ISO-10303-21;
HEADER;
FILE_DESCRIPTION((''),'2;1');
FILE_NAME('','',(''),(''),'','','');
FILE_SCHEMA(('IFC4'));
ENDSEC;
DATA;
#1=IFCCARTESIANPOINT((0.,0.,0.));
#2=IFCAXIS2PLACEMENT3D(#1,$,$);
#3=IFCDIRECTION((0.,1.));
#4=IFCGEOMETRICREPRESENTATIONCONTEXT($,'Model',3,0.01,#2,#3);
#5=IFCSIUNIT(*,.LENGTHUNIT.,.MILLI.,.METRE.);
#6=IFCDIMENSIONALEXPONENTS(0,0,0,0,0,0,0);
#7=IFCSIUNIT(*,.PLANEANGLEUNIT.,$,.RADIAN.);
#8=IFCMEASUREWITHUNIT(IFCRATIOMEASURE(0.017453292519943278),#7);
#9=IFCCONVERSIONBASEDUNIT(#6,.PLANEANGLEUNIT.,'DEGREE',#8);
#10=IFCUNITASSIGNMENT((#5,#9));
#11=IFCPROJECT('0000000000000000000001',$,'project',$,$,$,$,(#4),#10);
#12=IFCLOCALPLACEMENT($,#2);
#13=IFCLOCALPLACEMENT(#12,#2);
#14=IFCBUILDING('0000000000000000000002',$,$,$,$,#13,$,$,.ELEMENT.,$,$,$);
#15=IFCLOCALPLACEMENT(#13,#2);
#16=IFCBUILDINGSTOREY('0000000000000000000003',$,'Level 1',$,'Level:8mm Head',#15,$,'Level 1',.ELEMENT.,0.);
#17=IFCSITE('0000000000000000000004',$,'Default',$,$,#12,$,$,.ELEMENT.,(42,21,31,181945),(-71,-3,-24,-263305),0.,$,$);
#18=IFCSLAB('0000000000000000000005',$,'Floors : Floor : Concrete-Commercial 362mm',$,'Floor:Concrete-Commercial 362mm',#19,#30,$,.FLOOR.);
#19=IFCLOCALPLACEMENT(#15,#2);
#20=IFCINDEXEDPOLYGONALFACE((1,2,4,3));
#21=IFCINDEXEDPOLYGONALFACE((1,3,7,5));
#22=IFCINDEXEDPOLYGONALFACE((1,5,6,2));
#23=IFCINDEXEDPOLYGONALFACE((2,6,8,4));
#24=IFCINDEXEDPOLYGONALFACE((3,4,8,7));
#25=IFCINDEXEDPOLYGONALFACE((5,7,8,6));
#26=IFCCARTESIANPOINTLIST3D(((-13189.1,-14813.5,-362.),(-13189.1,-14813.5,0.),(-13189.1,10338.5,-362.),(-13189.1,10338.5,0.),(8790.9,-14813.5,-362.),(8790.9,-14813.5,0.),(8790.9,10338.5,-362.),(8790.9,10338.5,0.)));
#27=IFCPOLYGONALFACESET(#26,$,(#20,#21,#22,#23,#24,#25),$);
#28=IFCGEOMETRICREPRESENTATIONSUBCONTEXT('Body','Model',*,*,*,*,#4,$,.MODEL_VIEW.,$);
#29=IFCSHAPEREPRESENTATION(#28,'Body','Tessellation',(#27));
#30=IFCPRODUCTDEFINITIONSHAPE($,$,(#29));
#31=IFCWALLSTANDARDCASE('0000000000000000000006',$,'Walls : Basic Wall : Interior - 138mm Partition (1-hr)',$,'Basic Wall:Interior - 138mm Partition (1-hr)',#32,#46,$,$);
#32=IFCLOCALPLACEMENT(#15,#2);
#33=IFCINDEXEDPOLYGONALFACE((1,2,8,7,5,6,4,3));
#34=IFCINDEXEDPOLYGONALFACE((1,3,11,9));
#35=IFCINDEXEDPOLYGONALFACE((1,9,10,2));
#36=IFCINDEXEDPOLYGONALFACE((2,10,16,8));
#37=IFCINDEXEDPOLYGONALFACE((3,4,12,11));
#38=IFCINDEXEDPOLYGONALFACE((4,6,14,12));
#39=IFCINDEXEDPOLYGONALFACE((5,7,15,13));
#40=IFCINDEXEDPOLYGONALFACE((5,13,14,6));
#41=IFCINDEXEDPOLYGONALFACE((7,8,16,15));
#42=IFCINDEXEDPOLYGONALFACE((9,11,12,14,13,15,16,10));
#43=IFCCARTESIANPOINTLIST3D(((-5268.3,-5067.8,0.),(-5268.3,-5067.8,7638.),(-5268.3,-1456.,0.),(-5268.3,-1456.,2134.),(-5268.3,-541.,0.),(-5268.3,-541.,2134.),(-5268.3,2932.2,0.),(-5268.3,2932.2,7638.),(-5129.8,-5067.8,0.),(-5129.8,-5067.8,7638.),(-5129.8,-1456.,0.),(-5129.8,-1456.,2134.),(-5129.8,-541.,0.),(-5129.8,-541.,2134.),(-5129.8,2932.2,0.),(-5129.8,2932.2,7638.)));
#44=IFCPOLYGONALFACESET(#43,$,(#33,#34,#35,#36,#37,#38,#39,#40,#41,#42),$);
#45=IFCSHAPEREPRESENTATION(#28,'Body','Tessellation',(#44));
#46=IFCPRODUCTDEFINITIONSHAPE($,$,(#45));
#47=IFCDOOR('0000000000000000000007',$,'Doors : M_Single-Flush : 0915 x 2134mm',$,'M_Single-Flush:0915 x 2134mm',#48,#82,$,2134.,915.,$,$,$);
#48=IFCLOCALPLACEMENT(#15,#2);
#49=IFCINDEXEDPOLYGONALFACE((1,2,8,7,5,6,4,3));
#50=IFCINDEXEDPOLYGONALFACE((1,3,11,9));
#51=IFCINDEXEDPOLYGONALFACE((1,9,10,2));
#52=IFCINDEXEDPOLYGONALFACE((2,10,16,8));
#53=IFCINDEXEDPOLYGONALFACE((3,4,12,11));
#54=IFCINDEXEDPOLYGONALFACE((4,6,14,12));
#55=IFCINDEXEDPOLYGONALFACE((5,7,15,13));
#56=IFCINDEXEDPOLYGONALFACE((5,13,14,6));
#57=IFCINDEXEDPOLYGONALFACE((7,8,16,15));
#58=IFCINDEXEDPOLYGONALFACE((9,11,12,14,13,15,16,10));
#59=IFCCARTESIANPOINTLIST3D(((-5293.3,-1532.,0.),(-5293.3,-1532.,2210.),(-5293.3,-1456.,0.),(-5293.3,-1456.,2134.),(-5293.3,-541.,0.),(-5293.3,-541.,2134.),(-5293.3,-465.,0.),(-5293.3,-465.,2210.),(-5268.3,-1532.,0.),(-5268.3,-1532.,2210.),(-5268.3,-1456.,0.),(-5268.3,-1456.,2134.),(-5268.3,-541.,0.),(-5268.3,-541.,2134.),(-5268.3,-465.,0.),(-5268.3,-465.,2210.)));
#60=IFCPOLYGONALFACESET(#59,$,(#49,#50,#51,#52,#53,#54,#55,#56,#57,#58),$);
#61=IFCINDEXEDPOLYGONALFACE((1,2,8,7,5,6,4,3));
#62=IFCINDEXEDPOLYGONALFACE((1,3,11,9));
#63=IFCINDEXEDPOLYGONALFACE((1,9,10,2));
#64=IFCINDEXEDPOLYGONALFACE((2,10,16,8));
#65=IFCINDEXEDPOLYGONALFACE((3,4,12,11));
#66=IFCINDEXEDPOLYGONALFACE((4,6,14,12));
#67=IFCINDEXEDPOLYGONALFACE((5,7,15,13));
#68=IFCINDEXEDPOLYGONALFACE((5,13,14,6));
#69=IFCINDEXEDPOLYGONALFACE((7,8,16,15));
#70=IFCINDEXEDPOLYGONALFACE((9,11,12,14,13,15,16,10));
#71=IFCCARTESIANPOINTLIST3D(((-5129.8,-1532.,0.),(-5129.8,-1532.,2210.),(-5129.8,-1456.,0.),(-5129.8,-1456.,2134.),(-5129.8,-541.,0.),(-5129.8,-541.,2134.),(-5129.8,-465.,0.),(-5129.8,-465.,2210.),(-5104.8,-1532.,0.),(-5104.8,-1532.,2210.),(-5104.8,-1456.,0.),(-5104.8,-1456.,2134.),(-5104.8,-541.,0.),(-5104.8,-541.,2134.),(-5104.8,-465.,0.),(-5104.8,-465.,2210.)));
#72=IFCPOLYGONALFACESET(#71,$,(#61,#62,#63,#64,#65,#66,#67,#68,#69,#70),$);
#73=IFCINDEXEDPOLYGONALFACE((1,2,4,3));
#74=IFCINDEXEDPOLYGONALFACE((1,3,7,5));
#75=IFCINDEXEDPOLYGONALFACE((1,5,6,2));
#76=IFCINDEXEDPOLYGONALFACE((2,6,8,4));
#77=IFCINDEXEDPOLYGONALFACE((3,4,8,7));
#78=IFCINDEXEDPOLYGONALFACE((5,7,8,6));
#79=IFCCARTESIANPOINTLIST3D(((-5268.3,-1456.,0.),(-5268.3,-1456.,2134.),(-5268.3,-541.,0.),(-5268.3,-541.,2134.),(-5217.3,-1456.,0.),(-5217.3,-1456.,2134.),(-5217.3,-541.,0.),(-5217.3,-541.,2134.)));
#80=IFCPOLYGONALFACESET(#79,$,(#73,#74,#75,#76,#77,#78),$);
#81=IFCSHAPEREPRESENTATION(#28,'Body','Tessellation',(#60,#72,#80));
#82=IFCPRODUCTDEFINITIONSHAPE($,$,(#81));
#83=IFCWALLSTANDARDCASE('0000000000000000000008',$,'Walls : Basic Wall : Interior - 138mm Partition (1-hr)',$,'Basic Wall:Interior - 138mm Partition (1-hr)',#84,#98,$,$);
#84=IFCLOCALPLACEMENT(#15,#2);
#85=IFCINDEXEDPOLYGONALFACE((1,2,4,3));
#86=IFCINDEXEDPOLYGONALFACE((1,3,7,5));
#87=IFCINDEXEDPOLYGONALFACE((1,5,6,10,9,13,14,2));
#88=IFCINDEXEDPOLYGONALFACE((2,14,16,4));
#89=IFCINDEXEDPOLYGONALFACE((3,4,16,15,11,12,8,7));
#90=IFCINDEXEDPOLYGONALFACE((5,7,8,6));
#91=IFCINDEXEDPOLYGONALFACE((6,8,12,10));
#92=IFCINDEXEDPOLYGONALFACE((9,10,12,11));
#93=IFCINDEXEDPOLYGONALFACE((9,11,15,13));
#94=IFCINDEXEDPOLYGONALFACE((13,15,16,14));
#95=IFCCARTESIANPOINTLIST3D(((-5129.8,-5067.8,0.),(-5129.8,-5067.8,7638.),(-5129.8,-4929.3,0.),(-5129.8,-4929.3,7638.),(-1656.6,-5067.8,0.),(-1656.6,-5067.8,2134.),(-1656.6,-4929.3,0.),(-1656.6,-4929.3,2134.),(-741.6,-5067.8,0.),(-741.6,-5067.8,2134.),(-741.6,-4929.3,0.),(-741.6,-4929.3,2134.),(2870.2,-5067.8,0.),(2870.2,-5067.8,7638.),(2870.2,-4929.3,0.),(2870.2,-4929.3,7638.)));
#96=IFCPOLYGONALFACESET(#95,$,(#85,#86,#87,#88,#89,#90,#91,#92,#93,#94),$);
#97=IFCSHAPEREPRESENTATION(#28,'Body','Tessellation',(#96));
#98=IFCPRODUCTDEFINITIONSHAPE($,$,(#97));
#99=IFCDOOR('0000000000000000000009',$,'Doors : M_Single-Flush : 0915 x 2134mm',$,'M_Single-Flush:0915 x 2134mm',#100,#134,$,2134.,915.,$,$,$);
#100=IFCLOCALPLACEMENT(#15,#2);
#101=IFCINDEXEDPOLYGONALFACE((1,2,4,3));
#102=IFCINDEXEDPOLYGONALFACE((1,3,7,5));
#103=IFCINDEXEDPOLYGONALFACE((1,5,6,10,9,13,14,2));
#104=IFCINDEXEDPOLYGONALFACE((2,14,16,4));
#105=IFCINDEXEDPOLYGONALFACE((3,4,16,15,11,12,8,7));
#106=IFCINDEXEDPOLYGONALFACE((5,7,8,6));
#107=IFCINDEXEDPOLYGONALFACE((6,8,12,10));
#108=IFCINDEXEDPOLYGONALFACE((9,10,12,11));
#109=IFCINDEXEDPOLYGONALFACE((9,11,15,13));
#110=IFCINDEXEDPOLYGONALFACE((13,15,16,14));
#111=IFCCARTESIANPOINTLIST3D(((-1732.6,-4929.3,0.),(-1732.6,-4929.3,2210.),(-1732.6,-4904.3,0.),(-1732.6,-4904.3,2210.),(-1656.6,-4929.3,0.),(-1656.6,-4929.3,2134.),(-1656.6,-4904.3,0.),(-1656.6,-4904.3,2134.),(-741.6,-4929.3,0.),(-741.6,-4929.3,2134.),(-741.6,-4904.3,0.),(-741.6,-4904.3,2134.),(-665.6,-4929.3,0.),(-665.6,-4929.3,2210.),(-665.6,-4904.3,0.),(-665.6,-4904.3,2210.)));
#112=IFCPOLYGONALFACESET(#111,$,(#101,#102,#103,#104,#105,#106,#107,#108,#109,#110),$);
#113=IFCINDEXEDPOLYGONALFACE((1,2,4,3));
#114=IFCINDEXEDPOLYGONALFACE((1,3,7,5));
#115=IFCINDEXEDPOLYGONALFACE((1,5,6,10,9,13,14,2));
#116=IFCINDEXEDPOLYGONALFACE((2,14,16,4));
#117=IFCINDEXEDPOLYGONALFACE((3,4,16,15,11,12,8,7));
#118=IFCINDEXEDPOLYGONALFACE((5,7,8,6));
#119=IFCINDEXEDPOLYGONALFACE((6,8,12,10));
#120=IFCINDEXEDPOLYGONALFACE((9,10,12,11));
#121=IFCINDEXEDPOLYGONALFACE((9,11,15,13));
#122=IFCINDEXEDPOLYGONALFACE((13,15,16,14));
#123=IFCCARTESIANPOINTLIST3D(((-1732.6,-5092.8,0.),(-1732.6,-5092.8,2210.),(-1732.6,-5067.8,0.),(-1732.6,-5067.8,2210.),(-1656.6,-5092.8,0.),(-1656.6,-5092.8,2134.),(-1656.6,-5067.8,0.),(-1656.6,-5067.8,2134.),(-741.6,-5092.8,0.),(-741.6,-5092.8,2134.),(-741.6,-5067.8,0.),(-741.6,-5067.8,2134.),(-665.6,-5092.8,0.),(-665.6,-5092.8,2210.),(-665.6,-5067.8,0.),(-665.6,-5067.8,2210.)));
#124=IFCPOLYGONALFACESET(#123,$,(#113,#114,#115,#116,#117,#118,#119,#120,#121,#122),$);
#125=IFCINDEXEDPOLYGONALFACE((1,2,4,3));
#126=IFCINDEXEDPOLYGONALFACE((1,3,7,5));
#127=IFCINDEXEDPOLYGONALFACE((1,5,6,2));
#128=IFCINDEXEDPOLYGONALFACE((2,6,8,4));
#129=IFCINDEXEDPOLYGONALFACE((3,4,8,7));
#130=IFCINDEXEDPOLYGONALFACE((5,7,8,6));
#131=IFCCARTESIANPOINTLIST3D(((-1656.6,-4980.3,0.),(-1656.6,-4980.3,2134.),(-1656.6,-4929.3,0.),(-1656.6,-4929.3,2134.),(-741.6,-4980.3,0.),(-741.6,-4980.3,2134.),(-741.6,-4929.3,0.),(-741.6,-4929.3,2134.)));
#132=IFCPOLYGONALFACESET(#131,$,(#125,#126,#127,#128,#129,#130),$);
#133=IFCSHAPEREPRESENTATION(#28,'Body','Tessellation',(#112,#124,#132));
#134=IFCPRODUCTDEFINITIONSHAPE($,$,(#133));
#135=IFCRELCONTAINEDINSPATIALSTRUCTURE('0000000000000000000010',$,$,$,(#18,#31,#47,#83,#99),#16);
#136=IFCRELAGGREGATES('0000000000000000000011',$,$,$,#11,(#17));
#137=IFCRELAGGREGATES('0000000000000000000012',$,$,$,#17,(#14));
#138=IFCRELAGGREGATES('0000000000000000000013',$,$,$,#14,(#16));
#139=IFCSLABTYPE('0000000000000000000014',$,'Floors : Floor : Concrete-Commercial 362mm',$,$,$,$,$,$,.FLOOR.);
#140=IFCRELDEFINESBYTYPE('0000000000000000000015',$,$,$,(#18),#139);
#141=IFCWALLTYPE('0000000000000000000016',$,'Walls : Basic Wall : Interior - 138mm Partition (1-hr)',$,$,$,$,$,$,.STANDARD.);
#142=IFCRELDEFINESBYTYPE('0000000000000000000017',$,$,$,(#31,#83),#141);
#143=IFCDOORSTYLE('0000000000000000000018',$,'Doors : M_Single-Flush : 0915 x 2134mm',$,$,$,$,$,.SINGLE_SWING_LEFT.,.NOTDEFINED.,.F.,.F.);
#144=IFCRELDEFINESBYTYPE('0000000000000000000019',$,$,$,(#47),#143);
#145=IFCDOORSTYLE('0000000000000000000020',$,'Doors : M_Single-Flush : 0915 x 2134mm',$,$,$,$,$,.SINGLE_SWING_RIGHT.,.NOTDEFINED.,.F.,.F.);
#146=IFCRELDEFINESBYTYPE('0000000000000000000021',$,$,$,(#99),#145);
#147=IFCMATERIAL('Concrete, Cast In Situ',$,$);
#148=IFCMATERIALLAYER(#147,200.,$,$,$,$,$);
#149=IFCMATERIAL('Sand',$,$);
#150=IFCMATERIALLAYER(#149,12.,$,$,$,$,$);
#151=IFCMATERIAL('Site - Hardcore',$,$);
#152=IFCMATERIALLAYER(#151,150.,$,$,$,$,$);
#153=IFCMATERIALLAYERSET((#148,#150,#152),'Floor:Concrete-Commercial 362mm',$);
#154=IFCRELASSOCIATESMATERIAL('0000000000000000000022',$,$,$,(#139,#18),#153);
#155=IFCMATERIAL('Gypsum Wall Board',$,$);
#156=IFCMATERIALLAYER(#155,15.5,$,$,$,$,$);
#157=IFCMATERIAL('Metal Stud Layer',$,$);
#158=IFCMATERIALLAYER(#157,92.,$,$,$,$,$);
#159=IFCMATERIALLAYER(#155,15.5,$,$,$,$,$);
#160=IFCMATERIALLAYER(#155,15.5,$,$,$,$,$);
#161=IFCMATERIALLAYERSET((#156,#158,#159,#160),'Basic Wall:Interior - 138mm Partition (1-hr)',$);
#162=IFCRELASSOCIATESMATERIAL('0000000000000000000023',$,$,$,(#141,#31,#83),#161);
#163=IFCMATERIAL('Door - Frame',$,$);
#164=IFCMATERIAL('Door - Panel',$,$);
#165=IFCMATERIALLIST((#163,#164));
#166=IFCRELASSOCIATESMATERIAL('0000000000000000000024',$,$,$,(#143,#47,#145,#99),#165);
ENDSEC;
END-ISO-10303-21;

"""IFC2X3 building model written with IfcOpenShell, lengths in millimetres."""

from ifc_helpers import new_model, entity, si_unit, converted_unit, direction, frame, frame_2d, origin, place, context, subcontext, project, spatial, polyline, rectangle, outline, extrude, clip, bounded_halfspace, source, transform, mapped, material, material_list, layer, layer_set, layer_usage, type_object, type_shapes, element, fill, save


model = new_model("IFC2X3")

# Units and contexts
model_context = context("Model", 3, precision=0.01, world=origin(), true_north=direction((0.0, 1.0)))
body_context = subcontext(model_context, "Body", "Model", "MODEL_VIEW")
ifc_project = project(units=[si_unit("LENGTHUNIT", "METRE", prefix="MILLI"), converted_unit("PLANEANGLEUNIT", "DEGREE", entity("IfcRatioMeasure", 0.017453292519943278), si_unit("PLANEANGLEUNIT", "RADIAN"), dimensions=[0, 0, 0, 0, 0, 0, 0])], contexts=[model_context])

# Site, building, storey
site_placement = place(None, origin())
site = spatial("IfcSite", under=ifc_project, at=site_placement, Name="Default", CompositionType="ELEMENT", RefLatitude=(42, 21, 31, 181945), RefLongitude=(-71, -3, -24, -263305), RefElevation=0.0)
building_placement = place(site_placement, origin())
building = spatial("IfcBuilding", under=site, at=building_placement, CompositionType="ELEMENT")
storey_placement = place(building_placement, origin())
storey = spatial("IfcBuildingStorey", under=building, at=storey_placement, Name="Level 1", ObjectType="Level:8mm Head", LongName="Level 1", CompositionType="ELEMENT", Elevation=0.0)

# Slab
ifc_material_1 = material(Name="Concrete, Cast In Situ")
ifc_layer_1 = layer(ifc_material_1, 200.0)
ifc_material_2 = material(Name="Sand")
ifc_layer_2 = layer(ifc_material_2, 12.0)
ifc_material_3 = material(Name="Site - Hardcore")
ifc_layer_3 = layer(ifc_material_3, 150.0)
ifc_layer_set_1 = layer_set([ifc_layer_1, ifc_layer_2, ifc_layer_3], Name="Floor:Concrete-Commercial 362mm")
ifc_layer_usage_1 = layer_usage(ifc_layer_set_1, "AXIS3", "POSITIVE", 0.0)
slab_type = type_object("IfcSlabType", Name="Floors : Floor : Concrete-Commercial 362mm", PredefinedType="FLOOR", material=ifc_layer_set_1)
slab_placement = place(storey_placement, origin())
element("IfcSlab", 1, at=slab_placement, inside=storey, type_object=slab_type, material=ifc_layer_usage_1, Name="Floors : Floor : Concrete-Commercial 362mm", ObjectType="Floor:Concrete-Commercial 362mm", PredefinedType="FLOOR", context=body_context, shape_type="SweptSolid", body=[
    extrude(rectangle(XDim=25152.0, YDim=21980.0, at=frame_2d((0.0, 0.0), x_axis=(1.0, 0.0))), frame((-2199.1, -2237.5, 0.0), z_axis=(0.0, 0.0, -1.0), x_axis=(0.0, 1.0, 0.0)), (0.0, 0.0, 1.0), 362.0),
])

# Shared definitions
ifc_material_4 = material(Name="Metal Stud Layer")
ifc_material_5 = material(Name="Gypsum Wall Board")
ifc_layer_4 = layer(ifc_material_5, 15.5)
ifc_layer_5 = layer(ifc_material_4, 92.0)
ifc_layer_6 = layer(ifc_material_5, 15.5)
ifc_layer_7 = layer(ifc_material_5, 15.5)
ifc_layer_set_2 = layer_set([ifc_layer_4, ifc_layer_5, ifc_layer_6, ifc_layer_7], Name="Basic Wall:Interior - 138mm Partition (1-hr)")
wall_type_1 = type_object("IfcWallType", Name="Walls : Basic Wall : Interior - 138mm Partition (1-hr)", PredefinedType="STANDARD", material=ifc_layer_set_2)

# Walls, openings, doors
ifc_layer_usage_2 = layer_usage(ifc_layer_set_2, "AXIS2", "NEGATIVE", 69.2)
wall_1_placement = place(storey_placement, frame((-5199.1, 2932.2, 0.0), z_axis=(0.0, 0.0, 1.0), x_axis=(0.0, -1.0, 0.0)))
wall_1 = element("IfcWallStandardCase", 2, at=wall_1_placement, inside=storey, type_object=wall_type_1, material=ifc_layer_usage_2, Name="Walls : Basic Wall : Interior - 138mm Partition (1-hr)", ObjectType="Basic Wall:Interior - 138mm Partition (1-hr)", context=body_context, shape_type="Clipping", body=[
    clip(extrude(rectangle(XDim=8000.0, YDim=138.5, at=frame_2d((4000.0, 0.0), x_axis=(1.0, 0.0))), origin(), (0.0, 0.0, 1.0), 7638.0), bounded_halfspace(frame((0.0, -69.2, 7638.0), z_axis=(0.0, 0.0, -1.0), x_axis=(1.0, 0.0, 0.0)), True, frame((0.0, -69.2, 7638.0)), polyline([(0.0, 0.0), (2438400.0, 0.0), (2438400.0, 42214.8), (2396185.2, 42214.8), (0.0, 42214.8), (0.0, 0.0)]))),
])
opening_1_placement = place(wall_1_placement, frame((4388.2, 69.3, 0.0)))
opening_1 = element("IfcOpeningElement", 3, at=opening_1_placement, cuts=wall_1, ObjectType="Opening", context=body_context, shape_type="SweptSolid", body=[
    extrude(rectangle(XDim=915.0, YDim=2134.0, at=frame_2d((1067.0, 457.5), x_axis=(0.0, -1.0))), frame((0.0, 0.0, 0.0), z_axis=(0.0, -1.0, 0.0), x_axis=(0.0, 0.0, 1.0)), (0.0, 0.0, 1.0), 138.5),
])
ifc_material_6 = material(Name="Door - Frame")
ifc_material_7 = material(Name="Door - Panel")
ifc_material_list = material_list([ifc_material_6, ifc_material_7])
door_style_1 = type_object("IfcDoorStyle", Name="Doors : M_Single-Flush : 0915 x 2134mm", ConstructionType="NOTDEFINED", OperationType="SINGLE_SWING_LEFT", ParameterTakesPrecedence=False, Sizeable=False, material=ifc_material_list)
shared_shape_1 = source(origin(), body_context, "Body", "SweptSolid", [
    extrude(outline(polyline([(-533.5, -1124.0), (533.5, -1124.0), (533.5, 1086.0), (457.5, 1086.0), (457.5, -1048.0), (-457.5, -1048.0), (-457.5, 1086.0), (-533.5, 1086.0), (-533.5, -1124.0)])), frame((457.5, 163.5, 1086.0), z_axis=(0.0, -1.0, 0.0), x_axis=(-1.0, 0.0, 0.0)), (0.0, 0.0, 1.0), 25.0),
    extrude(outline(polyline([(-1124.0, -533.5), (1086.0, -533.5), (1086.0, -457.5), (-1048.0, -457.5), (-1048.0, 457.5), (1086.0, 457.5), (1086.0, 533.5), (-1124.0, 533.5), (-1124.0, -533.5)])), frame((457.5, 0.0, 1086.0), z_axis=(0.0, -1.0, 0.0), x_axis=(0.0, 0.0, -1.0)), (0.0, 0.0, 1.0), 25.0),
    extrude(rectangle(XDim=915.0, YDim=51.0, at=frame_2d((0.0, 0.0), x_axis=(1.0, 0.0))), frame((457.5, 113.0, 0.0)), (0.0, 0.0, 1.0), 2134.0),
])
type_shapes(door_style_1, [shared_shape_1])
door_1_placement = place(opening_1_placement, frame((0.0, 0.0, 0.0), z_axis=(0.0, 0.0, 1.0), x_axis=(-1.0, 0.0, 0.0)))
door_1 = element("IfcDoor", 4, at=door_1_placement, inside=storey, type_object=door_style_1, material=ifc_material_list, Name="Doors : M_Single-Flush : 0915 x 2134mm", ObjectType="M_Single-Flush:0915 x 2134mm", OverallHeight=2134.0, OverallWidth=915.0, context=body_context, shape_type="MappedRepresentation", body=[
    mapped(shared_shape_1, transform((0.0, 0.0, 0.0), scale=1.0)),
])
fill(opening_1, door_1)
wall_2_placement = place(storey_placement, frame((-5129.8, -4998.5, 0.0)))
wall_2 = element("IfcWallStandardCase", 5, at=wall_2_placement, inside=storey, type_object=wall_type_1, material=ifc_layer_usage_2, Name="Walls : Basic Wall : Interior - 138mm Partition (1-hr)", ObjectType="Basic Wall:Interior - 138mm Partition (1-hr)", context=body_context, shape_type="Clipping", body=[
    clip(extrude(rectangle(XDim=8000.0, YDim=138.5, at=frame_2d((4000.0, 0.0), x_axis=(1.0, 0.0))), origin(), (0.0, 0.0, 1.0), 7638.0), bounded_halfspace(frame((0.0, -69.2, 7638.0), z_axis=(0.0, 0.0, -1.0), x_axis=(0.0, -1.0, 0.0)), True, frame((0.0, -69.2, 7638.0)), polyline([(0.0, 0.0), (2396185.2, 0.0), (2438400.0, 0.0), (2438400.0, 42214.8), (0.0, 42214.8), (0.0, 0.0)]))),
])
opening_2_placement = place(wall_2_placement, frame((3473.2, -69.3, 0.0)))
opening_2 = element("IfcOpeningElement", 6, at=opening_2_placement, cuts=wall_2, ObjectType="Opening", context=body_context, shape_type="SweptSolid", body=[
    extrude(rectangle(XDim=915.0, YDim=2134.0, at=frame_2d((1067.0, 457.5), x_axis=(0.0, 1.0))), frame((0.0, 0.0, 0.0), z_axis=(0.0, 1.0, 0.0), x_axis=(0.0, 0.0, 1.0)), (0.0, 0.0, 1.0), 138.5),
])
door_style_2 = type_object("IfcDoorStyle", Name="Doors : M_Single-Flush : 0915 x 2134mm", ConstructionType="NOTDEFINED", OperationType="SINGLE_SWING_RIGHT", ParameterTakesPrecedence=False, Sizeable=False, material=ifc_material_list)
shared_shape_2 = source(origin(), body_context, "Body", "SweptSolid", [
    extrude(outline(polyline([(-533.5, -1124.0), (533.5, -1124.0), (533.5, 1086.0), (457.5, 1086.0), (457.5, -1048.0), (-457.5, -1048.0), (-457.5, 1086.0), (-533.5, 1086.0), (-533.5, -1124.0)])), frame((457.5, 138.5, 1086.0), z_axis=(0.0, 1.0, 0.0), x_axis=(1.0, 0.0, 0.0)), (0.0, 0.0, 1.0), 25.0),
    extrude(outline(polyline([(-1124.0, -533.5), (1086.0, -533.5), (1086.0, -457.5), (-1048.0, -457.5), (-1048.0, 457.5), (1086.0, 457.5), (1086.0, 533.5), (-1124.0, 533.5), (-1124.0, -533.5)])), frame((457.5, -25.0, 1086.0), z_axis=(0.0, 1.0, 0.0), x_axis=(0.0, 0.0, -1.0)), (0.0, 0.0, 1.0), 25.0),
    extrude(rectangle(XDim=51.0, YDim=915.0, at=frame_2d((0.0, 0.0), x_axis=(1.0, 0.0))), frame((457.5, 113.0, 0.0), z_axis=(0.0, 0.0, 1.0), x_axis=(0.0, 1.0, 0.0)), (0.0, 0.0, 1.0), 2134.0),
])
type_shapes(door_style_2, [shared_shape_2])
door_2_placement = place(opening_2_placement, origin())
door_2 = element("IfcDoor", 7, at=door_2_placement, inside=storey, type_object=door_style_2, material=ifc_material_list, Name="Doors : M_Single-Flush : 0915 x 2134mm", ObjectType="M_Single-Flush:0915 x 2134mm", OverallHeight=2134.0, OverallWidth=915.0, context=body_context, shape_type="MappedRepresentation", body=[
    mapped(shared_shape_2, transform((0.0, 0.0, 0.0), scale=1.0)),
])
fill(opening_2, door_2)

save(model, "model.ifc")
